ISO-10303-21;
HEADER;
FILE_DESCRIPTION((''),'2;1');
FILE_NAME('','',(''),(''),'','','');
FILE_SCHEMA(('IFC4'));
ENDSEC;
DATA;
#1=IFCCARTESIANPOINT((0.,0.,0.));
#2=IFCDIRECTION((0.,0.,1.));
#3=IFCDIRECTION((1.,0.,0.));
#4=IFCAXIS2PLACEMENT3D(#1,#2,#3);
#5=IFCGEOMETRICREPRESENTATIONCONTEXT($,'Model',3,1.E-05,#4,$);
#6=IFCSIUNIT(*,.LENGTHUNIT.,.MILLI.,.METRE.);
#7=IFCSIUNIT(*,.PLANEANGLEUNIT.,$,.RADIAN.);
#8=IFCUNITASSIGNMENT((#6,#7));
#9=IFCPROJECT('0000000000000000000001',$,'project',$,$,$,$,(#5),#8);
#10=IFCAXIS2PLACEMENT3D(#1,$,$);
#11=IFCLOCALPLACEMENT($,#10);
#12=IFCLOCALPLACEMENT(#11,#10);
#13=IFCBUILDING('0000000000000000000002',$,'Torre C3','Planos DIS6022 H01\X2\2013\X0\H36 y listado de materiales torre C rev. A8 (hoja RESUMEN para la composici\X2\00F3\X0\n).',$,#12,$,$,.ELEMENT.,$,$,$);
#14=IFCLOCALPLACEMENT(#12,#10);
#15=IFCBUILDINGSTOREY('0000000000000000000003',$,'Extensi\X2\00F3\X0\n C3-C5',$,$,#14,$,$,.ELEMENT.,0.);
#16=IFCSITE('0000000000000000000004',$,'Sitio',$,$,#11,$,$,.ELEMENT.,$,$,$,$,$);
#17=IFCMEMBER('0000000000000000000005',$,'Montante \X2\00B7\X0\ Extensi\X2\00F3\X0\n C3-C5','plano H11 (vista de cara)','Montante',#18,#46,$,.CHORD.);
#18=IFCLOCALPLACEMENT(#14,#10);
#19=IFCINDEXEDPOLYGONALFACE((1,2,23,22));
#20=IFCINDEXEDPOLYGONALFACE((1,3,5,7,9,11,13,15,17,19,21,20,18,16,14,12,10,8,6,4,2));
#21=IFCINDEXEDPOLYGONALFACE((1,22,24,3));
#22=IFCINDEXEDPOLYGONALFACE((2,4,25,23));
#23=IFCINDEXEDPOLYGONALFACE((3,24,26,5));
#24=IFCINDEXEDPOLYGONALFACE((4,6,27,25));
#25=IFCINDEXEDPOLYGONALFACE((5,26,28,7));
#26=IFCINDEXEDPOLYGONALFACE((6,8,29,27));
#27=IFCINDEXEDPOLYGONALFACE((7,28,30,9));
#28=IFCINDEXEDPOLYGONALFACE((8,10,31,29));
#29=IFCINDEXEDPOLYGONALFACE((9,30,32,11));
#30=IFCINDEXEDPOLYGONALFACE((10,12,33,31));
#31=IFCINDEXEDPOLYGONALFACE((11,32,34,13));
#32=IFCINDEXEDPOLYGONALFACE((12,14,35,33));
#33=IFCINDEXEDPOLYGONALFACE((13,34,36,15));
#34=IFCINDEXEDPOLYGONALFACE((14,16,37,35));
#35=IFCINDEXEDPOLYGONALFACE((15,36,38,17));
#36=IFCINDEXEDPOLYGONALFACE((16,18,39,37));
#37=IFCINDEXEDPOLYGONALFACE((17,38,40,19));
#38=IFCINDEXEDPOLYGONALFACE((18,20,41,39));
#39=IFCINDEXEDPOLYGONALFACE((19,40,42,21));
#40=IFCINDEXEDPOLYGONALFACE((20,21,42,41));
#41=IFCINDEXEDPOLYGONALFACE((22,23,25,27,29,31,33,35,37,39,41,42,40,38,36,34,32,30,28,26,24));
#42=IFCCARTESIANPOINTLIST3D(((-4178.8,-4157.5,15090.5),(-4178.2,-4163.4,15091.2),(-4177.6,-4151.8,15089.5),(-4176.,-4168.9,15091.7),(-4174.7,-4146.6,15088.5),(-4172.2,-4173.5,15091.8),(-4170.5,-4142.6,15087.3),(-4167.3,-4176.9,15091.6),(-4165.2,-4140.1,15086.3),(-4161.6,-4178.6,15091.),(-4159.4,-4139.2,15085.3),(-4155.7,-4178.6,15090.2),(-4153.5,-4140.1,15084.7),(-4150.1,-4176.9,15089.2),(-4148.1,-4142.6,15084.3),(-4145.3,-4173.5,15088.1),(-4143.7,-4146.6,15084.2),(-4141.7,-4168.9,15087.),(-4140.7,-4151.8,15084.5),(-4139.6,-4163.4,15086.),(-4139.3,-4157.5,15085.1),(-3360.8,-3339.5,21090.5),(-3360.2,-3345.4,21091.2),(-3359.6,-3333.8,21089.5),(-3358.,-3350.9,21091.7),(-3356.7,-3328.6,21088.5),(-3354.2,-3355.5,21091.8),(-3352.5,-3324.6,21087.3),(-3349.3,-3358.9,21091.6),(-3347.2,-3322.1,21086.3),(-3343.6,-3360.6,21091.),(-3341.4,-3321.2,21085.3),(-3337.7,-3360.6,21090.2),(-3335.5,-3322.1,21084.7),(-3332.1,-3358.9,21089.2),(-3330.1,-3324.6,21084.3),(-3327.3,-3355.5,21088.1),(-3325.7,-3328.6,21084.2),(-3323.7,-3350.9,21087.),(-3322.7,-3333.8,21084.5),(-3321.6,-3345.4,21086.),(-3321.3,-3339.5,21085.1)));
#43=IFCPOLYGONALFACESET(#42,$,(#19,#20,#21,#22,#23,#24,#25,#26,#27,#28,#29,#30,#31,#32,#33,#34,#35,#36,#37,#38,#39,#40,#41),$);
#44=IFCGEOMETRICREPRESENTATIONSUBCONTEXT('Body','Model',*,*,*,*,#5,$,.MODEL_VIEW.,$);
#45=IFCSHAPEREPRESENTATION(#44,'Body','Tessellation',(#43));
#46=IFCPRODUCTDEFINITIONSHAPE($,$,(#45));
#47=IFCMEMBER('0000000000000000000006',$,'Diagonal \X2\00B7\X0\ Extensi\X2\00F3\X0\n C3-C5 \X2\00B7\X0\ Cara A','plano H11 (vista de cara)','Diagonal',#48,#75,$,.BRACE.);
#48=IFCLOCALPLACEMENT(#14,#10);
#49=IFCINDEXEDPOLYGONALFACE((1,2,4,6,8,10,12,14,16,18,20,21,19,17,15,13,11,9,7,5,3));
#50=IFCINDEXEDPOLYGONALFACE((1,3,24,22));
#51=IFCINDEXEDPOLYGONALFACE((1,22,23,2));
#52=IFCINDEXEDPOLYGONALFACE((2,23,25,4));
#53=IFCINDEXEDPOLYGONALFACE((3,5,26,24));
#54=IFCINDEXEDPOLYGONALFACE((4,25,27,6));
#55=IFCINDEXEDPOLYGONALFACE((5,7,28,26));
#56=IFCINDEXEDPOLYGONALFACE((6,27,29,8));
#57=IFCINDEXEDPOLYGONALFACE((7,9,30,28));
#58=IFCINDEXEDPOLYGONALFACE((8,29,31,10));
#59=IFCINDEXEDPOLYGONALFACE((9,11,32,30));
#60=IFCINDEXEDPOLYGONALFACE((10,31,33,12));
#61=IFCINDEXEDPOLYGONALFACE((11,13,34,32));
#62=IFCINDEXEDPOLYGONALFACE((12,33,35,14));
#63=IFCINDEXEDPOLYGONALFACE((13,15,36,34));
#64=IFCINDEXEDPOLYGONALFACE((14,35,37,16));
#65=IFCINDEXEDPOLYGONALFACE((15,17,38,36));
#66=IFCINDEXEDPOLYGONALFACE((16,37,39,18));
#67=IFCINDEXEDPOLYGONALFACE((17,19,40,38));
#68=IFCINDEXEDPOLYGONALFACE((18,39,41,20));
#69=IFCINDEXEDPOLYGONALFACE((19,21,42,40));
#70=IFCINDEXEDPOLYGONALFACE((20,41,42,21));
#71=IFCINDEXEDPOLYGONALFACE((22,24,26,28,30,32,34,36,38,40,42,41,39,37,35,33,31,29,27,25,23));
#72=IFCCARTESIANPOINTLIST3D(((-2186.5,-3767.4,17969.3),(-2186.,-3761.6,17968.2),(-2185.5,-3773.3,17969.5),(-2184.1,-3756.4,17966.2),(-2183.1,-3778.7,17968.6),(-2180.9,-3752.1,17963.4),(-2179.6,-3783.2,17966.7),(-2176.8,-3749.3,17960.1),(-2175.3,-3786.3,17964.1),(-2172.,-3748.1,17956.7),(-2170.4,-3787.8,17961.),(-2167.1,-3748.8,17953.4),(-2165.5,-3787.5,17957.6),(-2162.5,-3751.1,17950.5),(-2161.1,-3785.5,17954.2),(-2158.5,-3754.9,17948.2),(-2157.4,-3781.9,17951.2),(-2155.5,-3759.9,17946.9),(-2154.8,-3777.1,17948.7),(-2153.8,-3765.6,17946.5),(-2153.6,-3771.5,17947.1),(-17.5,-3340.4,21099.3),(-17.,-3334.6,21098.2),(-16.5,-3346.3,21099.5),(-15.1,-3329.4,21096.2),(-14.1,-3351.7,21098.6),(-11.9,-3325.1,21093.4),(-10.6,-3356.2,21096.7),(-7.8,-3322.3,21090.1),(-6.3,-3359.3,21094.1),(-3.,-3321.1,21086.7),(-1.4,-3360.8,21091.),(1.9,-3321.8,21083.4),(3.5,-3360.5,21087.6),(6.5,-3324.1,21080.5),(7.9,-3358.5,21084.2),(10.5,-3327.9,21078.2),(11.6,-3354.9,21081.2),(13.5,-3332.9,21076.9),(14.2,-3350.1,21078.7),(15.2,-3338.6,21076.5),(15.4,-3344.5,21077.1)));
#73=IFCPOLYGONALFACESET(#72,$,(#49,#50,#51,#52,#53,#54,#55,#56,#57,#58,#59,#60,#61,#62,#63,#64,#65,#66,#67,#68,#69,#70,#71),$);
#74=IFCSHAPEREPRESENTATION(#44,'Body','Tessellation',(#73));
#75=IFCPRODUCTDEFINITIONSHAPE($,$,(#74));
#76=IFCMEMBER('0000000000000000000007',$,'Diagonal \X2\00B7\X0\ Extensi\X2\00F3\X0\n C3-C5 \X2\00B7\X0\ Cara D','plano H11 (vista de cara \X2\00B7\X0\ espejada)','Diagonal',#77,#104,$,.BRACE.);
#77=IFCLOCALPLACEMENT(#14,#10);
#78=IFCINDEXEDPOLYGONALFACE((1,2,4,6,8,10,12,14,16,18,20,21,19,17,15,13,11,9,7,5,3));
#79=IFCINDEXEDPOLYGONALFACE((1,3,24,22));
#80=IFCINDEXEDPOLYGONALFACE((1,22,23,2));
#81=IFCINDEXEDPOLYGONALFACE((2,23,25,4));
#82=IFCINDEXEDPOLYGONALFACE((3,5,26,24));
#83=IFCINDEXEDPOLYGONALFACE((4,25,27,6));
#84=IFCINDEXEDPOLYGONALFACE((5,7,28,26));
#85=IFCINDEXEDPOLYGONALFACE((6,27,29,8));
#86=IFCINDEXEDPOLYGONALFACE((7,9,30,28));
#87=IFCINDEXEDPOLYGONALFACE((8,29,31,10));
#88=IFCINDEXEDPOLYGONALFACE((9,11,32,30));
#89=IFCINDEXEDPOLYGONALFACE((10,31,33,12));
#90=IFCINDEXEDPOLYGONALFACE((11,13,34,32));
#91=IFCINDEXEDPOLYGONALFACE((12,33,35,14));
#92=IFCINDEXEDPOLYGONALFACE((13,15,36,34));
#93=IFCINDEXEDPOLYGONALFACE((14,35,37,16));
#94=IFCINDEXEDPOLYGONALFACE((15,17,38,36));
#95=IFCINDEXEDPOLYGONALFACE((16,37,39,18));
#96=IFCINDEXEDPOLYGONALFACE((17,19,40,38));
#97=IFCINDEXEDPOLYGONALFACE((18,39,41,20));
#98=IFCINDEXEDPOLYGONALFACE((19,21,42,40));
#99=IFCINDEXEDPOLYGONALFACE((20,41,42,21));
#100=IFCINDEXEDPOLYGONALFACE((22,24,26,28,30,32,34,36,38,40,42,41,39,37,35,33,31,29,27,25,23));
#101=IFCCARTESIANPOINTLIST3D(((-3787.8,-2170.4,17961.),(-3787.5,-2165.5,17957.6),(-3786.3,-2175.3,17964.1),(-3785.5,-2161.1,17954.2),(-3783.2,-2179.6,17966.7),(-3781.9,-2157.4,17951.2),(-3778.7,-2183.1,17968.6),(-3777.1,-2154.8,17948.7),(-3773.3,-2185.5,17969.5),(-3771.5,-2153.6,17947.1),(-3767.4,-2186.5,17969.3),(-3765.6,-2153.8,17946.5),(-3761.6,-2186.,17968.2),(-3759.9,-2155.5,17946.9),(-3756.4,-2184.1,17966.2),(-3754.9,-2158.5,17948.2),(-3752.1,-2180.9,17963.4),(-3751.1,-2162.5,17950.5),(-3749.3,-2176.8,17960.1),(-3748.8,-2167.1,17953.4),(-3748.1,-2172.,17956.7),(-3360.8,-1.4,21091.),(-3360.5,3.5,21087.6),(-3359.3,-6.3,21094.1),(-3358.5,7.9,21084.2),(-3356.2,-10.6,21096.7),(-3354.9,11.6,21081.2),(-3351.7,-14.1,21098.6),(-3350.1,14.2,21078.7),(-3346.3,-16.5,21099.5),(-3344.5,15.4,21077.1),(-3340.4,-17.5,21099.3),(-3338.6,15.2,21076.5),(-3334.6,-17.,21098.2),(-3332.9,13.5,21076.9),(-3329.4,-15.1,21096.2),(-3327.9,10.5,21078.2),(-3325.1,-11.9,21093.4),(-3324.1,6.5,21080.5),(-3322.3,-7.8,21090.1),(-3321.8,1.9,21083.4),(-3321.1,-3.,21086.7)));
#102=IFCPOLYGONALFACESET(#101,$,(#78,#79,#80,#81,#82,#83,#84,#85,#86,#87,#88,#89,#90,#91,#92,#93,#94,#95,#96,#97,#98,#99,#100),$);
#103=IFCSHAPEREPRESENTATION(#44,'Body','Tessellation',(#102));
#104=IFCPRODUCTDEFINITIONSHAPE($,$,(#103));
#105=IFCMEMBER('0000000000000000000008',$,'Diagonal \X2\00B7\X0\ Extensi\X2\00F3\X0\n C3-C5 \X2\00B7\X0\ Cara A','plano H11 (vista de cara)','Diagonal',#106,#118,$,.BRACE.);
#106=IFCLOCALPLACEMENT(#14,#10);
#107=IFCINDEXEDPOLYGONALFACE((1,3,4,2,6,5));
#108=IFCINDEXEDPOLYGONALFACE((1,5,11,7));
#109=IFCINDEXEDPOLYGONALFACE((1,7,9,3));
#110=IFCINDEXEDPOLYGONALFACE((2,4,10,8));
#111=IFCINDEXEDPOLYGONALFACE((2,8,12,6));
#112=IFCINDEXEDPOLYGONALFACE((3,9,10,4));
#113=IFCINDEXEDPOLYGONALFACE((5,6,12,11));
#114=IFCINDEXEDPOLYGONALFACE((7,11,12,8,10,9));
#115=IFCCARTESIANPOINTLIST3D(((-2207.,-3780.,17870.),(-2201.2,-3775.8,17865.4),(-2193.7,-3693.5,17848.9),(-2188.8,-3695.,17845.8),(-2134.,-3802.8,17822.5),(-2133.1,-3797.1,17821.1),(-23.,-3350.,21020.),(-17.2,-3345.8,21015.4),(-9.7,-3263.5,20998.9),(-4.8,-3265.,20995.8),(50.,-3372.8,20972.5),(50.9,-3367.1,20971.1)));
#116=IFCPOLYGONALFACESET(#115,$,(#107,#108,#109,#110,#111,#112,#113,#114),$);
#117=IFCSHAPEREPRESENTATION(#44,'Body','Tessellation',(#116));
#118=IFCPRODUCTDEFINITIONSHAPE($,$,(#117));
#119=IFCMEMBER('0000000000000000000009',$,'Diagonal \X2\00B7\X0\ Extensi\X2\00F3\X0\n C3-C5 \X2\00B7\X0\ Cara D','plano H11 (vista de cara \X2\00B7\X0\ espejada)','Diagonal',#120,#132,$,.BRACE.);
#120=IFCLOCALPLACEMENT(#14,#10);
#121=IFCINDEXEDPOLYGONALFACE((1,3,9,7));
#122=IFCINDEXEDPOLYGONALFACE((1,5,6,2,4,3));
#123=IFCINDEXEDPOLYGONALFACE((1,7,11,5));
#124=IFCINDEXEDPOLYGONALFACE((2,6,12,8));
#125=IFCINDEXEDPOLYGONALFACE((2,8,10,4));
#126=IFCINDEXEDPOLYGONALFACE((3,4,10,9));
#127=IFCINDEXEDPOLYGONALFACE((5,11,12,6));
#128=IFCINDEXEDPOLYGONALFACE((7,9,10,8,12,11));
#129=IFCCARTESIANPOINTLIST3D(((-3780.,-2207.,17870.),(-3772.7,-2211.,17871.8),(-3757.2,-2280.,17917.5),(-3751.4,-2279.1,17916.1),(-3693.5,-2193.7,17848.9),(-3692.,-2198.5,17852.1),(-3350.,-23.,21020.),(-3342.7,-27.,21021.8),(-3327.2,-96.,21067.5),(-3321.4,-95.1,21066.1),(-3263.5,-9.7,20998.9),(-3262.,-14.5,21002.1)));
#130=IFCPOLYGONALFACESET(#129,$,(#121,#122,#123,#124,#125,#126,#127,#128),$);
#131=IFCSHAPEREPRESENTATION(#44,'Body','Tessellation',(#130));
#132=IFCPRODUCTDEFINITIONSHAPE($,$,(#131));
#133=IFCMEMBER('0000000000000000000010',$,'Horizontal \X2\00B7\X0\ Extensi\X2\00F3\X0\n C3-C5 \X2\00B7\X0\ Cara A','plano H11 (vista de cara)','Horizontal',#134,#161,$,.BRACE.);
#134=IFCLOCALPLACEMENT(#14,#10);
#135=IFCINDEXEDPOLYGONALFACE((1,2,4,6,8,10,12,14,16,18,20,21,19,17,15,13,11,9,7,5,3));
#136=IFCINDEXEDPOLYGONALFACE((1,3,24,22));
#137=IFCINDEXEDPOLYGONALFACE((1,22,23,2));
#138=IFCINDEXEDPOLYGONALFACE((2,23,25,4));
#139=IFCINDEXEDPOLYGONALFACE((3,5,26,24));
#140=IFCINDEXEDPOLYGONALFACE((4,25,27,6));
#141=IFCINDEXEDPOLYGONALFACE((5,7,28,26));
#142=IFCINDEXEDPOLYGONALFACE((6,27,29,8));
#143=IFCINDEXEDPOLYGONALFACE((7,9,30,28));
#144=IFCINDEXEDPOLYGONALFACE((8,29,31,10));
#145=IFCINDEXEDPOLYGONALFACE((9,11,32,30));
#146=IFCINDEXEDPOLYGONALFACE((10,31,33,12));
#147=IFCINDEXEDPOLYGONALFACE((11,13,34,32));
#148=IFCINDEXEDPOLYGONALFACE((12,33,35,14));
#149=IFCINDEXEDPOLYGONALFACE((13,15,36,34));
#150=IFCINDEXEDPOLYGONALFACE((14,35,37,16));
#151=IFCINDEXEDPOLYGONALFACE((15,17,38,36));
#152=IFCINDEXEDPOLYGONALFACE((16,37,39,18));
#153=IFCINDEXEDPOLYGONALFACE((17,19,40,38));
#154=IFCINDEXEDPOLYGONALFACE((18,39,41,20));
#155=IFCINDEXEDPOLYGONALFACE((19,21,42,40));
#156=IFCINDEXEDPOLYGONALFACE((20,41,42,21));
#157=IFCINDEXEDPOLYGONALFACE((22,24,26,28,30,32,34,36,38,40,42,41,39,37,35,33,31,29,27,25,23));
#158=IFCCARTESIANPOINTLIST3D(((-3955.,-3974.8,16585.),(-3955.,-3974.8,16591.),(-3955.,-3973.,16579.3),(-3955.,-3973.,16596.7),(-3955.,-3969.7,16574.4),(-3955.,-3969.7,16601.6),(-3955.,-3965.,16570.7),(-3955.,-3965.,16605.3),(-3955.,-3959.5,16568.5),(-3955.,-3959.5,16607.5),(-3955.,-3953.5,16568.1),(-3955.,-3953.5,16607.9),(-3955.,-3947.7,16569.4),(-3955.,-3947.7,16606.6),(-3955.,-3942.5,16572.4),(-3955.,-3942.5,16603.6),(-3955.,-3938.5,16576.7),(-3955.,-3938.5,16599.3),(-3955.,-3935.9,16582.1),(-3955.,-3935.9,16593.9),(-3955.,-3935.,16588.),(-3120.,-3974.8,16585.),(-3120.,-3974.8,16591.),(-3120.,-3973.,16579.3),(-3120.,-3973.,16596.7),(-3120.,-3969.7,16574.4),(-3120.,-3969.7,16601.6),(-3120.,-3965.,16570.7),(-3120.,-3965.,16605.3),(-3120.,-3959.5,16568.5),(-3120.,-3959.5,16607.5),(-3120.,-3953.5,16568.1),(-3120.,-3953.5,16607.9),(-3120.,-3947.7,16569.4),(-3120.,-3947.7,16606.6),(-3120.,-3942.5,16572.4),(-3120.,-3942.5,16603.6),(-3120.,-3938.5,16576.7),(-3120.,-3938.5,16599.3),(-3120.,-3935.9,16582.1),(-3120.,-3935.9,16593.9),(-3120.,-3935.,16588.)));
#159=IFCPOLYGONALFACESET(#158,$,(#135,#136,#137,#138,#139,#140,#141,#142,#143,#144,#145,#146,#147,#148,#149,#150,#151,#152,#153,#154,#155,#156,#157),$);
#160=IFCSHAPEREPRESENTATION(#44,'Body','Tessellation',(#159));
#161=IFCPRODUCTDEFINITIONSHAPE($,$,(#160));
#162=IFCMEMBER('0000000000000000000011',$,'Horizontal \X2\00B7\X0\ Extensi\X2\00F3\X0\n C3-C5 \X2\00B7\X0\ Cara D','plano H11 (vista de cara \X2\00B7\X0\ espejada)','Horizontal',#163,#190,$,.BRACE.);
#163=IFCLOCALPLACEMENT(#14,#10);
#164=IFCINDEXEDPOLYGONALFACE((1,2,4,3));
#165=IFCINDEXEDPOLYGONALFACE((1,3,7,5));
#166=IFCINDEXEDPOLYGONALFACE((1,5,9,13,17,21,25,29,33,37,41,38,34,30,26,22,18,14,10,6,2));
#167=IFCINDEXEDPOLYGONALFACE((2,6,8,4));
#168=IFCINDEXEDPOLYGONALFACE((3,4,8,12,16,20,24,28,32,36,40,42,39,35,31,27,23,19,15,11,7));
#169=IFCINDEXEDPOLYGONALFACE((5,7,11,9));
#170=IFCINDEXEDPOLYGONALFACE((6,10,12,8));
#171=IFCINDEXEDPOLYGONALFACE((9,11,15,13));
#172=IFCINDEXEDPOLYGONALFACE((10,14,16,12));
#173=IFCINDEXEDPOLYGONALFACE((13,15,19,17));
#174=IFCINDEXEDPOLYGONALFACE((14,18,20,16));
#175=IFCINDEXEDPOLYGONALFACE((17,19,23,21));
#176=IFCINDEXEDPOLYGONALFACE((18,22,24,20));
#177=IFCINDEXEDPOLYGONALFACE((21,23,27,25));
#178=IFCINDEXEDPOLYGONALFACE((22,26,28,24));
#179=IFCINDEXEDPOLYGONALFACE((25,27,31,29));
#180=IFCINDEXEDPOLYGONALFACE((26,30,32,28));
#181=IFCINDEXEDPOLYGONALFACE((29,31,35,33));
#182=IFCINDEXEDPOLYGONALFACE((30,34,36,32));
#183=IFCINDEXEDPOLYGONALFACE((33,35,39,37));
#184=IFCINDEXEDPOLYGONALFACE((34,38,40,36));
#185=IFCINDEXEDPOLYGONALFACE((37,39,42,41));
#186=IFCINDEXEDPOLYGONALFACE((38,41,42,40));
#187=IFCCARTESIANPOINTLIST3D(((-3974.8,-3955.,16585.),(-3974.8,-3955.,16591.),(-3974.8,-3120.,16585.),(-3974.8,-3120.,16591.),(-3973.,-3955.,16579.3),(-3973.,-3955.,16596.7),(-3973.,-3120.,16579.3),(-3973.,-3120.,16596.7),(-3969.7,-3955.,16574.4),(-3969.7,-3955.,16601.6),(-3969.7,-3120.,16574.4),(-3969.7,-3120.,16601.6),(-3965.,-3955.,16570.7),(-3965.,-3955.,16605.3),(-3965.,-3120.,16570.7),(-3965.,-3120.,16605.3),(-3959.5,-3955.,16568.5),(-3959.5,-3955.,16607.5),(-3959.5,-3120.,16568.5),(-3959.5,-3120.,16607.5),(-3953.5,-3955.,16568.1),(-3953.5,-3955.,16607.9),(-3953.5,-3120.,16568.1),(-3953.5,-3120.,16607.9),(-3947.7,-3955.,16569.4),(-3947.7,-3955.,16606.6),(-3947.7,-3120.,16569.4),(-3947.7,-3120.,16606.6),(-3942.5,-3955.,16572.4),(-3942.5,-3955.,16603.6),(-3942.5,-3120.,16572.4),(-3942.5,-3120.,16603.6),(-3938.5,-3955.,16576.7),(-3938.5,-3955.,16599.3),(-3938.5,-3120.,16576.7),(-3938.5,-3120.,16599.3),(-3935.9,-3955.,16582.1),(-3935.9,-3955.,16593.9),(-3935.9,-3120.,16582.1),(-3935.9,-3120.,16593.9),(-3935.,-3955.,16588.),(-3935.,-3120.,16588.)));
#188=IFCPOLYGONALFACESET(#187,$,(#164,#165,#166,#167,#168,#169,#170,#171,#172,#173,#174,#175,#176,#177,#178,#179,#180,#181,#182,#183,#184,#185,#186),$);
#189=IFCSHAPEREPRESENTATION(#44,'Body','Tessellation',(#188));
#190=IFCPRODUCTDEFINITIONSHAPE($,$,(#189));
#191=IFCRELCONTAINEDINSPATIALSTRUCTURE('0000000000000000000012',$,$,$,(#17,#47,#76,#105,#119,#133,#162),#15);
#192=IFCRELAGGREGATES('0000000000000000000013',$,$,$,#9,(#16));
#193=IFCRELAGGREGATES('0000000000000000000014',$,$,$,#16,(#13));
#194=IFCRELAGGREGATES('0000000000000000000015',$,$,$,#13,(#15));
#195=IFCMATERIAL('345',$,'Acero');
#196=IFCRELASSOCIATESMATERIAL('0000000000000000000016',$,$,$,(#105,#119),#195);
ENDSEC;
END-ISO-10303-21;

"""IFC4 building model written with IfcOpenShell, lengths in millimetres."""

from ifc_helpers import new_model, si_unit, frame, frame_2d, origin, origin_with_axes, place, context, subcontext, project, spatial, circle, l_section, extrude, material, element, save


model = new_model("IFC4")

# Units and contexts
model_context = context("Model", 3, precision=1e-05, world=origin_with_axes())
body_context = subcontext(model_context, "Body", "Model", "MODEL_VIEW")
ifc_project = project(units=[si_unit("LENGTHUNIT", "METRE", prefix="MILLI"), si_unit("PLANEANGLEUNIT", "RADIAN")], contexts=[model_context])

# Site, building, storey
site_placement = place(None, origin())
site = spatial("IfcSite", under=ifc_project, at=site_placement, Name="Sitio", CompositionType="ELEMENT")
building_placement = place(site_placement, origin())
building = spatial("IfcBuilding", under=site, at=building_placement, Name="Torre C3", Description="Planos DIS6022 H01–H36 y listado de materiales torre C rev. A8 (hoja RESUMEN para la composición).", CompositionType="ELEMENT")
storey_placement = place(building_placement, origin())
storey = spatial("IfcBuildingStorey", under=building, at=storey_placement, Name="Extensión C3-C5", CompositionType="ELEMENT", Elevation=0.0)

# Members
member_placement = place(storey_placement, frame((-3341.0, -3341.0, 21088.0), z_axis=(-0.133868, -0.133868, -0.981916), x_axis=(-0.018083, 0.990999, -0.132641)))
element("IfcMember", 1, at=member_placement, inside=storey, Name="Montante · Extensión C3-C5", Description="plano H11 (vista de cara)", ObjectType="Montante", PredefinedType="CHORD", context=body_context, shape_type="SweptSolid", body=[
    extrude(circle(Radius=20.0), None, (0.0, 0.0, 1.0), 6110.5),
])
for number, where, z_axis, x_axis, name, description in (
    (2, (-1.0, -3341.0, 21088.0), (-0.566031, -0.111432, -0.816818), (0.14358, 0.962353, -0.230783), "Diagonal · Extensión C3-C5 · Cara A", "plano H11 (vista de cara)"),
    (3, (-3341.0, -1.0, 21088.0), (-0.111432, -0.566031, -0.816818), (0.962353, 0.14358, -0.230783), "Diagonal · Extensión C3-C5 · Cara D", "plano H11 (vista de cara · espejada)"),
):
    element("IfcMember", number, at=place(storey_placement, frame(where, z_axis=z_axis, x_axis=x_axis)), inside=storey, Name=name, Description=description, ObjectType="Diagonal", PredefinedType="BRACE", context=body_context, shape_type="SweptSolid", body=[
        extrude(circle(Radius=20.0), None, (0.0, 0.0, 1.0), 3831.9),
    ])
ifc_material_1 = material(Name="345", Category="Acero")
for number, where, z_axis, x_axis, name, description in (
    (4, (-23.0, -3350.0, 21020.0), (-0.566228, -0.111483, -0.816675), (0.148288, 0.960867, -0.233979), "Diagonal · Extensión C3-C5 · Cara A", "plano H11 (vista de cara)"),
    (5, (-3350.0, -23.0, 21020.0), (-0.111483, -0.566228, -0.816675), (0.960867, 0.148288, -0.233979), "Diagonal · Extensión C3-C5 · Cara D", "plano H11 (vista de cara · espejada)"),
):
    element("IfcMember", number, at=place(storey_placement, frame(where, z_axis=z_axis, x_axis=x_axis)), inside=storey, material=ifc_material_1, Name=name, Description=description, ObjectType="Diagonal", PredefinedType="BRACE", context=body_context, shape_type="SweptSolid", body=[
        extrude(l_section(Depth=90.0, Width=90.0, Thickness=6.0, at=frame_2d((45.0, 45.0))), None, (0.0, 0.0, 1.0), 3857.1),
    ])
for number, where, z_axis, x_axis, name, description in (
    (6, (-3120.0, -3955.0, 16588.0), (-1.0, 0.0, 0.0), (0.0, 1.0, 0.0), "Horizontal · Extensión C3-C5 · Cara A", "plano H11 (vista de cara)"),
    (7, (-3955.0, -3120.0, 16588.0), (0.0, -1.0, 0.0), (1.0, 0.0, 0.0), "Horizontal · Extensión C3-C5 · Cara D", "plano H11 (vista de cara · espejada)"),
):
    element("IfcMember", number, at=place(storey_placement, frame(where, z_axis=z_axis, x_axis=x_axis)), inside=storey, Name=name, Description=description, ObjectType="Horizontal", PredefinedType="BRACE", context=body_context, shape_type="SweptSolid", body=[
        extrude(circle(Radius=20.0), None, (0.0, 0.0, 1.0), 835.0),
    ])

save(model, "model.ifc")
